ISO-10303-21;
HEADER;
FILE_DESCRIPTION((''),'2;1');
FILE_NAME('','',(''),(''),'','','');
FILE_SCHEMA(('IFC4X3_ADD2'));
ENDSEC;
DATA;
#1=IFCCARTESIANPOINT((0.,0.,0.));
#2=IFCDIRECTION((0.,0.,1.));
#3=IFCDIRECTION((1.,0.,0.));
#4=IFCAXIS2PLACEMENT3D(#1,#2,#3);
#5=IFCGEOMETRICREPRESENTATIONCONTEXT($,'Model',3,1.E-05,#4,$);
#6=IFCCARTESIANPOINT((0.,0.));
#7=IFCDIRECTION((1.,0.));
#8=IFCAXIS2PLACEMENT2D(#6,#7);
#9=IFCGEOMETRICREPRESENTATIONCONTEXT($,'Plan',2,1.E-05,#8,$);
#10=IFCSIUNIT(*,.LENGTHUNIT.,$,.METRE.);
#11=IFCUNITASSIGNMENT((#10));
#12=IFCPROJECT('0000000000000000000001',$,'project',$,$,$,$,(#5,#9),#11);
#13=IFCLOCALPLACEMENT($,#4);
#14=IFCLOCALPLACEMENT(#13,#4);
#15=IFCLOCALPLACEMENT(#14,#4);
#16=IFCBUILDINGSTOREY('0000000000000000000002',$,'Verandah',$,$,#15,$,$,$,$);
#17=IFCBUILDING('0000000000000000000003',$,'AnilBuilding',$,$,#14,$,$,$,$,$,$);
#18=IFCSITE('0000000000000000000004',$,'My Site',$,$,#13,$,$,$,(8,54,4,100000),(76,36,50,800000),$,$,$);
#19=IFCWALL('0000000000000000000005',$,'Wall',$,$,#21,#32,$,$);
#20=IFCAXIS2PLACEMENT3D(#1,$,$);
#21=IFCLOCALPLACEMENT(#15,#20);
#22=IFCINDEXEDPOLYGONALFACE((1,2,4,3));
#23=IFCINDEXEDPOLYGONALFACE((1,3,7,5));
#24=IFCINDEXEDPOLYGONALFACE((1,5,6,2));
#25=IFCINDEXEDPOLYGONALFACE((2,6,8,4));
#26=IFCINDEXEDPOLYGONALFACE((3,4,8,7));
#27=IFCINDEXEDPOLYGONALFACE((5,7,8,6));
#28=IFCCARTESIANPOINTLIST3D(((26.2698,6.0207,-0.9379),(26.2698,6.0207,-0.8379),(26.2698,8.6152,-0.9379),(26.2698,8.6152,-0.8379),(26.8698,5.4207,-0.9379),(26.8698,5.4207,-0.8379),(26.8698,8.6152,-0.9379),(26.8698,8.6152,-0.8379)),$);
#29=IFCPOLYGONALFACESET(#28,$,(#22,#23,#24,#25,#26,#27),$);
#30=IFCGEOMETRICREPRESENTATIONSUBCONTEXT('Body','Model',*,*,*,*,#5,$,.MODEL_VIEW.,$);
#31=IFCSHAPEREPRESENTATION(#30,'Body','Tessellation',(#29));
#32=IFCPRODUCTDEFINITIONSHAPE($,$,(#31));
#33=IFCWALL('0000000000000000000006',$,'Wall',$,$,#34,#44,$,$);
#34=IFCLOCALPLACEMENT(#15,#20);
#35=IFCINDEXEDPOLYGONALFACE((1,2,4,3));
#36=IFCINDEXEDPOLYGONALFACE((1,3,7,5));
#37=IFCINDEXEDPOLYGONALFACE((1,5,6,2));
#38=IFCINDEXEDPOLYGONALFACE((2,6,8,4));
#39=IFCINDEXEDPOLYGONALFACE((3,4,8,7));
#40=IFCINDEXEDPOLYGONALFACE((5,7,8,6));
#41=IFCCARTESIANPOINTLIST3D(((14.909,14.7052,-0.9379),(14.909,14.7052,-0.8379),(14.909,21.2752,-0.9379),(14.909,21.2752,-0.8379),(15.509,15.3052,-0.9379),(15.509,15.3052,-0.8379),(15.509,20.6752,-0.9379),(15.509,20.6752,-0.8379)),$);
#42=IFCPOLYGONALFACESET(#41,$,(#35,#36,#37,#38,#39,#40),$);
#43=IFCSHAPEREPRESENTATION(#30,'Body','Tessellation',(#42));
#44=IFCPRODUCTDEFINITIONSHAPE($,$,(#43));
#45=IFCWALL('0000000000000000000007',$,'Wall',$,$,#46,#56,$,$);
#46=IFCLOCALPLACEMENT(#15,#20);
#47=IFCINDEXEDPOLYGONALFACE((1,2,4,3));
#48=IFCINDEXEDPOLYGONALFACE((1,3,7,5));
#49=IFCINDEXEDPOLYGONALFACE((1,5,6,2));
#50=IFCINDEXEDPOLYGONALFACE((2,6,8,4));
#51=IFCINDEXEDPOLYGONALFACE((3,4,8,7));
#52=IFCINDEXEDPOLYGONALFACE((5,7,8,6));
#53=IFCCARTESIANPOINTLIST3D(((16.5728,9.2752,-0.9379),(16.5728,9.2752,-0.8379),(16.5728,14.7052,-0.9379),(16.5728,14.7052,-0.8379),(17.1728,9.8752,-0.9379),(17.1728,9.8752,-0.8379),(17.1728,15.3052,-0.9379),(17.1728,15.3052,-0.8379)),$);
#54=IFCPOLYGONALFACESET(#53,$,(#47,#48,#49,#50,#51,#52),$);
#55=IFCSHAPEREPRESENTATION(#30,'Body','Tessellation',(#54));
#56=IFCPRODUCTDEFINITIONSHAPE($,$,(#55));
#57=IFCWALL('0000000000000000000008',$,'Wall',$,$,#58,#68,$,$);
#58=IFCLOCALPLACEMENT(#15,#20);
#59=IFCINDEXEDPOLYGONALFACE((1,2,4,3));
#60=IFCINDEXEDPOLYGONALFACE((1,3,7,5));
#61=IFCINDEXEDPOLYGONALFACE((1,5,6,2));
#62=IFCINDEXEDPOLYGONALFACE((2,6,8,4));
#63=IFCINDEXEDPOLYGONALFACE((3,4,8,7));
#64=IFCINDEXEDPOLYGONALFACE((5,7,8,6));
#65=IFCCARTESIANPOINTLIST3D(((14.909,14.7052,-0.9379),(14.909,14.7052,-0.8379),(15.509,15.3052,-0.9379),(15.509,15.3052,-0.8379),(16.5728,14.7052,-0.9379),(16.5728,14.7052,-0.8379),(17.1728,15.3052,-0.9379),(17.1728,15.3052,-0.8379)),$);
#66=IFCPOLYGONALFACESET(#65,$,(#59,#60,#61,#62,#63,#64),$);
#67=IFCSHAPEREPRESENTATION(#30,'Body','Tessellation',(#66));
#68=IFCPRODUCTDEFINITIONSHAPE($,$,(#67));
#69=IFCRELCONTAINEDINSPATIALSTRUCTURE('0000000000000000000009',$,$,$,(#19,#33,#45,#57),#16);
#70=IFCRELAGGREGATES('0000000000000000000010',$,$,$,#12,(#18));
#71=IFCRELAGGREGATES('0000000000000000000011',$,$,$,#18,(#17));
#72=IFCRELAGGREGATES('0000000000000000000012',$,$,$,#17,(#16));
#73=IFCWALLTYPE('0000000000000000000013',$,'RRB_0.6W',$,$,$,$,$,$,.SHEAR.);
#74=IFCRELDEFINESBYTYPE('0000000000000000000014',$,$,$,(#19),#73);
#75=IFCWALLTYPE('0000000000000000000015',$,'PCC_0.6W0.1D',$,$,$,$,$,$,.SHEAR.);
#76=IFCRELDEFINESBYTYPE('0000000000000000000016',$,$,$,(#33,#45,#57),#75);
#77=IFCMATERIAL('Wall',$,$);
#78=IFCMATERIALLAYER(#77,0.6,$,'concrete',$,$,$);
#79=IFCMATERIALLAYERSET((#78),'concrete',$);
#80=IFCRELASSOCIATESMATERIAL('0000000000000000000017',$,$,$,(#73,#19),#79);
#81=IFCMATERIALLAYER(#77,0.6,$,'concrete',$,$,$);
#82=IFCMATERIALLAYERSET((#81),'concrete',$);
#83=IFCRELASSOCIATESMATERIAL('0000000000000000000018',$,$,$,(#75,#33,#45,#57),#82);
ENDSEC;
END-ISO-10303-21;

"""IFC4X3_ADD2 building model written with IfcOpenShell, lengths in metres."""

from ifc_helpers import new_model, si_unit, frame, origin_with_axes, origin_2d_with_axis, place, context, subcontext, project, spatial, line, indexed_curve, outline, extrude, material, layer, layer_set, layer_usage, type_object, element, save


model = new_model("IFC4X3_ADD2")

# Units and contexts
model_context = context("Model", 3, precision=1e-05, world=origin_with_axes())
plan_context = context("Plan", 2, precision=1e-05, world=origin_2d_with_axis())
body_context = subcontext(model_context, "Body", "Model", "MODEL_VIEW")
ifc_project = project(units=[si_unit("LENGTHUNIT", "METRE")], contexts=[model_context, plan_context])

# Site, building, storey
site_placement = place(None, origin_with_axes())
site = spatial("IfcSite", under=ifc_project, at=site_placement, Name="My Site", RefLatitude=(8, 54, 4, 100000), RefLongitude=(76, 36, 50, 800000))
building_placement = place(site_placement, origin_with_axes())
building = spatial("IfcBuilding", under=site, at=building_placement, Name="AnilBuilding")
storey_placement = place(building_placement, origin_with_axes())
storey = spatial("IfcBuildingStorey", under=building, at=storey_placement, Name="Verandah")

# Walls
ifc_material_1 = material(Name="Wall")
ifc_layer_1 = layer(ifc_material_1, 0.6, Name="concrete")
ifc_layer_set_1 = layer_set([ifc_layer_1], Name="concrete")
wall_type_1 = type_object("IfcWallType", Name="RRB_0.6W", PredefinedType="SHEAR", material=ifc_layer_set_1)
ifc_layer_usage_1 = layer_usage(ifc_layer_set_1, "AXIS2", "POSITIVE", 0.0)
wall_1_placement = place(storey_placement, frame((26.8698, 6.0207, -0.9379), z_axis=(0.0, 0.0, 1.0), x_axis=(0.000001, 1.0, 0.0)))
element("IfcWall", 1, at=wall_1_placement, inside=storey, type_object=wall_type_1, material=ifc_layer_usage_1, Name="Wall", context=body_context, shape_type="SweptSolid", body=[
    extrude(outline(indexed_curve([(-0.6, 0.0), (0.0, 0.6), (2.5945, 0.6), (2.5945, 0.0)], segments=[line(1, 2, 3, 4, 1)])), origin_with_axes(), (0.0, 0.0, 1.0), 0.1),
])
ifc_layer_2 = layer(ifc_material_1, 0.6, Name="concrete")
ifc_layer_set_2 = layer_set([ifc_layer_2], Name="concrete")
ifc_layer_usage_2 = layer_usage(ifc_layer_set_2, "AXIS2", "POSITIVE", 0.0)
wall_type_2 = type_object("IfcWallType", Name="PCC_0.6W0.1D", PredefinedType="SHEAR", material=ifc_layer_set_2)
wall_2_placement = place(storey_placement, frame((15.509, 15.3052, -0.9379), z_axis=(0.0, 0.0, 1.0), x_axis=(0.000001, 1.0, 0.0)))
element("IfcWall", 2, at=wall_2_placement, inside=storey, type_object=wall_type_2, material=ifc_layer_usage_2, Name="Wall", context=body_context, shape_type="SweptSolid", body=[
    extrude(outline(indexed_curve([(0.0, 0.0), (-0.6, 0.6), (5.97, 0.6), (5.37, 0.0)], segments=[line(1, 2, 3, 4, 1)])), origin_with_axes(), (0.0, 0.0, 1.0), 0.1),
])
ifc_layer_usage_3 = layer_usage(ifc_layer_set_2, "AXIS2", "POSITIVE", 0.0)
wall_3_placement = place(storey_placement, frame((17.1728, 9.8752, -0.9379), z_axis=(0.0, 0.0, 1.0), x_axis=(0.000001, 1.0, 0.0)))
element("IfcWall", 3, at=wall_3_placement, inside=storey, type_object=wall_type_2, material=ifc_layer_usage_3, Name="Wall", context=body_context, shape_type="SweptSolid", body=[
    extrude(outline(indexed_curve([(0.0, 0.0), (-0.6, 0.6), (4.83, 0.6), (5.43, 0.0)], segments=[line(1, 2, 3, 4, 1)])), origin_with_axes(), (0.0, 0.0, 1.0), 0.1),
])
ifc_layer_usage_4 = layer_usage(ifc_layer_set_2, "AXIS2", "POSITIVE", 0.0)
wall_4_placement = place(storey_placement, frame((17.1728, 15.3052, -0.9379), z_axis=(0.0, 0.0, 1.0), x_axis=(-1.0, 0.000001, 0.0)))
element("IfcWall", 4, at=wall_4_placement, inside=storey, type_object=wall_type_2, material=ifc_layer_usage_4, Name="Wall", context=body_context, shape_type="SweptSolid", body=[
    extrude(outline(indexed_curve([(0.0, 0.0), (0.6, 0.6), (2.2638, 0.6), (1.6638, 0.0)], segments=[line(1, 2, 3, 4, 1)])), origin_with_axes(), (0.0, 0.0, 1.0), 0.1),
])

save(model, "model.ifc")
